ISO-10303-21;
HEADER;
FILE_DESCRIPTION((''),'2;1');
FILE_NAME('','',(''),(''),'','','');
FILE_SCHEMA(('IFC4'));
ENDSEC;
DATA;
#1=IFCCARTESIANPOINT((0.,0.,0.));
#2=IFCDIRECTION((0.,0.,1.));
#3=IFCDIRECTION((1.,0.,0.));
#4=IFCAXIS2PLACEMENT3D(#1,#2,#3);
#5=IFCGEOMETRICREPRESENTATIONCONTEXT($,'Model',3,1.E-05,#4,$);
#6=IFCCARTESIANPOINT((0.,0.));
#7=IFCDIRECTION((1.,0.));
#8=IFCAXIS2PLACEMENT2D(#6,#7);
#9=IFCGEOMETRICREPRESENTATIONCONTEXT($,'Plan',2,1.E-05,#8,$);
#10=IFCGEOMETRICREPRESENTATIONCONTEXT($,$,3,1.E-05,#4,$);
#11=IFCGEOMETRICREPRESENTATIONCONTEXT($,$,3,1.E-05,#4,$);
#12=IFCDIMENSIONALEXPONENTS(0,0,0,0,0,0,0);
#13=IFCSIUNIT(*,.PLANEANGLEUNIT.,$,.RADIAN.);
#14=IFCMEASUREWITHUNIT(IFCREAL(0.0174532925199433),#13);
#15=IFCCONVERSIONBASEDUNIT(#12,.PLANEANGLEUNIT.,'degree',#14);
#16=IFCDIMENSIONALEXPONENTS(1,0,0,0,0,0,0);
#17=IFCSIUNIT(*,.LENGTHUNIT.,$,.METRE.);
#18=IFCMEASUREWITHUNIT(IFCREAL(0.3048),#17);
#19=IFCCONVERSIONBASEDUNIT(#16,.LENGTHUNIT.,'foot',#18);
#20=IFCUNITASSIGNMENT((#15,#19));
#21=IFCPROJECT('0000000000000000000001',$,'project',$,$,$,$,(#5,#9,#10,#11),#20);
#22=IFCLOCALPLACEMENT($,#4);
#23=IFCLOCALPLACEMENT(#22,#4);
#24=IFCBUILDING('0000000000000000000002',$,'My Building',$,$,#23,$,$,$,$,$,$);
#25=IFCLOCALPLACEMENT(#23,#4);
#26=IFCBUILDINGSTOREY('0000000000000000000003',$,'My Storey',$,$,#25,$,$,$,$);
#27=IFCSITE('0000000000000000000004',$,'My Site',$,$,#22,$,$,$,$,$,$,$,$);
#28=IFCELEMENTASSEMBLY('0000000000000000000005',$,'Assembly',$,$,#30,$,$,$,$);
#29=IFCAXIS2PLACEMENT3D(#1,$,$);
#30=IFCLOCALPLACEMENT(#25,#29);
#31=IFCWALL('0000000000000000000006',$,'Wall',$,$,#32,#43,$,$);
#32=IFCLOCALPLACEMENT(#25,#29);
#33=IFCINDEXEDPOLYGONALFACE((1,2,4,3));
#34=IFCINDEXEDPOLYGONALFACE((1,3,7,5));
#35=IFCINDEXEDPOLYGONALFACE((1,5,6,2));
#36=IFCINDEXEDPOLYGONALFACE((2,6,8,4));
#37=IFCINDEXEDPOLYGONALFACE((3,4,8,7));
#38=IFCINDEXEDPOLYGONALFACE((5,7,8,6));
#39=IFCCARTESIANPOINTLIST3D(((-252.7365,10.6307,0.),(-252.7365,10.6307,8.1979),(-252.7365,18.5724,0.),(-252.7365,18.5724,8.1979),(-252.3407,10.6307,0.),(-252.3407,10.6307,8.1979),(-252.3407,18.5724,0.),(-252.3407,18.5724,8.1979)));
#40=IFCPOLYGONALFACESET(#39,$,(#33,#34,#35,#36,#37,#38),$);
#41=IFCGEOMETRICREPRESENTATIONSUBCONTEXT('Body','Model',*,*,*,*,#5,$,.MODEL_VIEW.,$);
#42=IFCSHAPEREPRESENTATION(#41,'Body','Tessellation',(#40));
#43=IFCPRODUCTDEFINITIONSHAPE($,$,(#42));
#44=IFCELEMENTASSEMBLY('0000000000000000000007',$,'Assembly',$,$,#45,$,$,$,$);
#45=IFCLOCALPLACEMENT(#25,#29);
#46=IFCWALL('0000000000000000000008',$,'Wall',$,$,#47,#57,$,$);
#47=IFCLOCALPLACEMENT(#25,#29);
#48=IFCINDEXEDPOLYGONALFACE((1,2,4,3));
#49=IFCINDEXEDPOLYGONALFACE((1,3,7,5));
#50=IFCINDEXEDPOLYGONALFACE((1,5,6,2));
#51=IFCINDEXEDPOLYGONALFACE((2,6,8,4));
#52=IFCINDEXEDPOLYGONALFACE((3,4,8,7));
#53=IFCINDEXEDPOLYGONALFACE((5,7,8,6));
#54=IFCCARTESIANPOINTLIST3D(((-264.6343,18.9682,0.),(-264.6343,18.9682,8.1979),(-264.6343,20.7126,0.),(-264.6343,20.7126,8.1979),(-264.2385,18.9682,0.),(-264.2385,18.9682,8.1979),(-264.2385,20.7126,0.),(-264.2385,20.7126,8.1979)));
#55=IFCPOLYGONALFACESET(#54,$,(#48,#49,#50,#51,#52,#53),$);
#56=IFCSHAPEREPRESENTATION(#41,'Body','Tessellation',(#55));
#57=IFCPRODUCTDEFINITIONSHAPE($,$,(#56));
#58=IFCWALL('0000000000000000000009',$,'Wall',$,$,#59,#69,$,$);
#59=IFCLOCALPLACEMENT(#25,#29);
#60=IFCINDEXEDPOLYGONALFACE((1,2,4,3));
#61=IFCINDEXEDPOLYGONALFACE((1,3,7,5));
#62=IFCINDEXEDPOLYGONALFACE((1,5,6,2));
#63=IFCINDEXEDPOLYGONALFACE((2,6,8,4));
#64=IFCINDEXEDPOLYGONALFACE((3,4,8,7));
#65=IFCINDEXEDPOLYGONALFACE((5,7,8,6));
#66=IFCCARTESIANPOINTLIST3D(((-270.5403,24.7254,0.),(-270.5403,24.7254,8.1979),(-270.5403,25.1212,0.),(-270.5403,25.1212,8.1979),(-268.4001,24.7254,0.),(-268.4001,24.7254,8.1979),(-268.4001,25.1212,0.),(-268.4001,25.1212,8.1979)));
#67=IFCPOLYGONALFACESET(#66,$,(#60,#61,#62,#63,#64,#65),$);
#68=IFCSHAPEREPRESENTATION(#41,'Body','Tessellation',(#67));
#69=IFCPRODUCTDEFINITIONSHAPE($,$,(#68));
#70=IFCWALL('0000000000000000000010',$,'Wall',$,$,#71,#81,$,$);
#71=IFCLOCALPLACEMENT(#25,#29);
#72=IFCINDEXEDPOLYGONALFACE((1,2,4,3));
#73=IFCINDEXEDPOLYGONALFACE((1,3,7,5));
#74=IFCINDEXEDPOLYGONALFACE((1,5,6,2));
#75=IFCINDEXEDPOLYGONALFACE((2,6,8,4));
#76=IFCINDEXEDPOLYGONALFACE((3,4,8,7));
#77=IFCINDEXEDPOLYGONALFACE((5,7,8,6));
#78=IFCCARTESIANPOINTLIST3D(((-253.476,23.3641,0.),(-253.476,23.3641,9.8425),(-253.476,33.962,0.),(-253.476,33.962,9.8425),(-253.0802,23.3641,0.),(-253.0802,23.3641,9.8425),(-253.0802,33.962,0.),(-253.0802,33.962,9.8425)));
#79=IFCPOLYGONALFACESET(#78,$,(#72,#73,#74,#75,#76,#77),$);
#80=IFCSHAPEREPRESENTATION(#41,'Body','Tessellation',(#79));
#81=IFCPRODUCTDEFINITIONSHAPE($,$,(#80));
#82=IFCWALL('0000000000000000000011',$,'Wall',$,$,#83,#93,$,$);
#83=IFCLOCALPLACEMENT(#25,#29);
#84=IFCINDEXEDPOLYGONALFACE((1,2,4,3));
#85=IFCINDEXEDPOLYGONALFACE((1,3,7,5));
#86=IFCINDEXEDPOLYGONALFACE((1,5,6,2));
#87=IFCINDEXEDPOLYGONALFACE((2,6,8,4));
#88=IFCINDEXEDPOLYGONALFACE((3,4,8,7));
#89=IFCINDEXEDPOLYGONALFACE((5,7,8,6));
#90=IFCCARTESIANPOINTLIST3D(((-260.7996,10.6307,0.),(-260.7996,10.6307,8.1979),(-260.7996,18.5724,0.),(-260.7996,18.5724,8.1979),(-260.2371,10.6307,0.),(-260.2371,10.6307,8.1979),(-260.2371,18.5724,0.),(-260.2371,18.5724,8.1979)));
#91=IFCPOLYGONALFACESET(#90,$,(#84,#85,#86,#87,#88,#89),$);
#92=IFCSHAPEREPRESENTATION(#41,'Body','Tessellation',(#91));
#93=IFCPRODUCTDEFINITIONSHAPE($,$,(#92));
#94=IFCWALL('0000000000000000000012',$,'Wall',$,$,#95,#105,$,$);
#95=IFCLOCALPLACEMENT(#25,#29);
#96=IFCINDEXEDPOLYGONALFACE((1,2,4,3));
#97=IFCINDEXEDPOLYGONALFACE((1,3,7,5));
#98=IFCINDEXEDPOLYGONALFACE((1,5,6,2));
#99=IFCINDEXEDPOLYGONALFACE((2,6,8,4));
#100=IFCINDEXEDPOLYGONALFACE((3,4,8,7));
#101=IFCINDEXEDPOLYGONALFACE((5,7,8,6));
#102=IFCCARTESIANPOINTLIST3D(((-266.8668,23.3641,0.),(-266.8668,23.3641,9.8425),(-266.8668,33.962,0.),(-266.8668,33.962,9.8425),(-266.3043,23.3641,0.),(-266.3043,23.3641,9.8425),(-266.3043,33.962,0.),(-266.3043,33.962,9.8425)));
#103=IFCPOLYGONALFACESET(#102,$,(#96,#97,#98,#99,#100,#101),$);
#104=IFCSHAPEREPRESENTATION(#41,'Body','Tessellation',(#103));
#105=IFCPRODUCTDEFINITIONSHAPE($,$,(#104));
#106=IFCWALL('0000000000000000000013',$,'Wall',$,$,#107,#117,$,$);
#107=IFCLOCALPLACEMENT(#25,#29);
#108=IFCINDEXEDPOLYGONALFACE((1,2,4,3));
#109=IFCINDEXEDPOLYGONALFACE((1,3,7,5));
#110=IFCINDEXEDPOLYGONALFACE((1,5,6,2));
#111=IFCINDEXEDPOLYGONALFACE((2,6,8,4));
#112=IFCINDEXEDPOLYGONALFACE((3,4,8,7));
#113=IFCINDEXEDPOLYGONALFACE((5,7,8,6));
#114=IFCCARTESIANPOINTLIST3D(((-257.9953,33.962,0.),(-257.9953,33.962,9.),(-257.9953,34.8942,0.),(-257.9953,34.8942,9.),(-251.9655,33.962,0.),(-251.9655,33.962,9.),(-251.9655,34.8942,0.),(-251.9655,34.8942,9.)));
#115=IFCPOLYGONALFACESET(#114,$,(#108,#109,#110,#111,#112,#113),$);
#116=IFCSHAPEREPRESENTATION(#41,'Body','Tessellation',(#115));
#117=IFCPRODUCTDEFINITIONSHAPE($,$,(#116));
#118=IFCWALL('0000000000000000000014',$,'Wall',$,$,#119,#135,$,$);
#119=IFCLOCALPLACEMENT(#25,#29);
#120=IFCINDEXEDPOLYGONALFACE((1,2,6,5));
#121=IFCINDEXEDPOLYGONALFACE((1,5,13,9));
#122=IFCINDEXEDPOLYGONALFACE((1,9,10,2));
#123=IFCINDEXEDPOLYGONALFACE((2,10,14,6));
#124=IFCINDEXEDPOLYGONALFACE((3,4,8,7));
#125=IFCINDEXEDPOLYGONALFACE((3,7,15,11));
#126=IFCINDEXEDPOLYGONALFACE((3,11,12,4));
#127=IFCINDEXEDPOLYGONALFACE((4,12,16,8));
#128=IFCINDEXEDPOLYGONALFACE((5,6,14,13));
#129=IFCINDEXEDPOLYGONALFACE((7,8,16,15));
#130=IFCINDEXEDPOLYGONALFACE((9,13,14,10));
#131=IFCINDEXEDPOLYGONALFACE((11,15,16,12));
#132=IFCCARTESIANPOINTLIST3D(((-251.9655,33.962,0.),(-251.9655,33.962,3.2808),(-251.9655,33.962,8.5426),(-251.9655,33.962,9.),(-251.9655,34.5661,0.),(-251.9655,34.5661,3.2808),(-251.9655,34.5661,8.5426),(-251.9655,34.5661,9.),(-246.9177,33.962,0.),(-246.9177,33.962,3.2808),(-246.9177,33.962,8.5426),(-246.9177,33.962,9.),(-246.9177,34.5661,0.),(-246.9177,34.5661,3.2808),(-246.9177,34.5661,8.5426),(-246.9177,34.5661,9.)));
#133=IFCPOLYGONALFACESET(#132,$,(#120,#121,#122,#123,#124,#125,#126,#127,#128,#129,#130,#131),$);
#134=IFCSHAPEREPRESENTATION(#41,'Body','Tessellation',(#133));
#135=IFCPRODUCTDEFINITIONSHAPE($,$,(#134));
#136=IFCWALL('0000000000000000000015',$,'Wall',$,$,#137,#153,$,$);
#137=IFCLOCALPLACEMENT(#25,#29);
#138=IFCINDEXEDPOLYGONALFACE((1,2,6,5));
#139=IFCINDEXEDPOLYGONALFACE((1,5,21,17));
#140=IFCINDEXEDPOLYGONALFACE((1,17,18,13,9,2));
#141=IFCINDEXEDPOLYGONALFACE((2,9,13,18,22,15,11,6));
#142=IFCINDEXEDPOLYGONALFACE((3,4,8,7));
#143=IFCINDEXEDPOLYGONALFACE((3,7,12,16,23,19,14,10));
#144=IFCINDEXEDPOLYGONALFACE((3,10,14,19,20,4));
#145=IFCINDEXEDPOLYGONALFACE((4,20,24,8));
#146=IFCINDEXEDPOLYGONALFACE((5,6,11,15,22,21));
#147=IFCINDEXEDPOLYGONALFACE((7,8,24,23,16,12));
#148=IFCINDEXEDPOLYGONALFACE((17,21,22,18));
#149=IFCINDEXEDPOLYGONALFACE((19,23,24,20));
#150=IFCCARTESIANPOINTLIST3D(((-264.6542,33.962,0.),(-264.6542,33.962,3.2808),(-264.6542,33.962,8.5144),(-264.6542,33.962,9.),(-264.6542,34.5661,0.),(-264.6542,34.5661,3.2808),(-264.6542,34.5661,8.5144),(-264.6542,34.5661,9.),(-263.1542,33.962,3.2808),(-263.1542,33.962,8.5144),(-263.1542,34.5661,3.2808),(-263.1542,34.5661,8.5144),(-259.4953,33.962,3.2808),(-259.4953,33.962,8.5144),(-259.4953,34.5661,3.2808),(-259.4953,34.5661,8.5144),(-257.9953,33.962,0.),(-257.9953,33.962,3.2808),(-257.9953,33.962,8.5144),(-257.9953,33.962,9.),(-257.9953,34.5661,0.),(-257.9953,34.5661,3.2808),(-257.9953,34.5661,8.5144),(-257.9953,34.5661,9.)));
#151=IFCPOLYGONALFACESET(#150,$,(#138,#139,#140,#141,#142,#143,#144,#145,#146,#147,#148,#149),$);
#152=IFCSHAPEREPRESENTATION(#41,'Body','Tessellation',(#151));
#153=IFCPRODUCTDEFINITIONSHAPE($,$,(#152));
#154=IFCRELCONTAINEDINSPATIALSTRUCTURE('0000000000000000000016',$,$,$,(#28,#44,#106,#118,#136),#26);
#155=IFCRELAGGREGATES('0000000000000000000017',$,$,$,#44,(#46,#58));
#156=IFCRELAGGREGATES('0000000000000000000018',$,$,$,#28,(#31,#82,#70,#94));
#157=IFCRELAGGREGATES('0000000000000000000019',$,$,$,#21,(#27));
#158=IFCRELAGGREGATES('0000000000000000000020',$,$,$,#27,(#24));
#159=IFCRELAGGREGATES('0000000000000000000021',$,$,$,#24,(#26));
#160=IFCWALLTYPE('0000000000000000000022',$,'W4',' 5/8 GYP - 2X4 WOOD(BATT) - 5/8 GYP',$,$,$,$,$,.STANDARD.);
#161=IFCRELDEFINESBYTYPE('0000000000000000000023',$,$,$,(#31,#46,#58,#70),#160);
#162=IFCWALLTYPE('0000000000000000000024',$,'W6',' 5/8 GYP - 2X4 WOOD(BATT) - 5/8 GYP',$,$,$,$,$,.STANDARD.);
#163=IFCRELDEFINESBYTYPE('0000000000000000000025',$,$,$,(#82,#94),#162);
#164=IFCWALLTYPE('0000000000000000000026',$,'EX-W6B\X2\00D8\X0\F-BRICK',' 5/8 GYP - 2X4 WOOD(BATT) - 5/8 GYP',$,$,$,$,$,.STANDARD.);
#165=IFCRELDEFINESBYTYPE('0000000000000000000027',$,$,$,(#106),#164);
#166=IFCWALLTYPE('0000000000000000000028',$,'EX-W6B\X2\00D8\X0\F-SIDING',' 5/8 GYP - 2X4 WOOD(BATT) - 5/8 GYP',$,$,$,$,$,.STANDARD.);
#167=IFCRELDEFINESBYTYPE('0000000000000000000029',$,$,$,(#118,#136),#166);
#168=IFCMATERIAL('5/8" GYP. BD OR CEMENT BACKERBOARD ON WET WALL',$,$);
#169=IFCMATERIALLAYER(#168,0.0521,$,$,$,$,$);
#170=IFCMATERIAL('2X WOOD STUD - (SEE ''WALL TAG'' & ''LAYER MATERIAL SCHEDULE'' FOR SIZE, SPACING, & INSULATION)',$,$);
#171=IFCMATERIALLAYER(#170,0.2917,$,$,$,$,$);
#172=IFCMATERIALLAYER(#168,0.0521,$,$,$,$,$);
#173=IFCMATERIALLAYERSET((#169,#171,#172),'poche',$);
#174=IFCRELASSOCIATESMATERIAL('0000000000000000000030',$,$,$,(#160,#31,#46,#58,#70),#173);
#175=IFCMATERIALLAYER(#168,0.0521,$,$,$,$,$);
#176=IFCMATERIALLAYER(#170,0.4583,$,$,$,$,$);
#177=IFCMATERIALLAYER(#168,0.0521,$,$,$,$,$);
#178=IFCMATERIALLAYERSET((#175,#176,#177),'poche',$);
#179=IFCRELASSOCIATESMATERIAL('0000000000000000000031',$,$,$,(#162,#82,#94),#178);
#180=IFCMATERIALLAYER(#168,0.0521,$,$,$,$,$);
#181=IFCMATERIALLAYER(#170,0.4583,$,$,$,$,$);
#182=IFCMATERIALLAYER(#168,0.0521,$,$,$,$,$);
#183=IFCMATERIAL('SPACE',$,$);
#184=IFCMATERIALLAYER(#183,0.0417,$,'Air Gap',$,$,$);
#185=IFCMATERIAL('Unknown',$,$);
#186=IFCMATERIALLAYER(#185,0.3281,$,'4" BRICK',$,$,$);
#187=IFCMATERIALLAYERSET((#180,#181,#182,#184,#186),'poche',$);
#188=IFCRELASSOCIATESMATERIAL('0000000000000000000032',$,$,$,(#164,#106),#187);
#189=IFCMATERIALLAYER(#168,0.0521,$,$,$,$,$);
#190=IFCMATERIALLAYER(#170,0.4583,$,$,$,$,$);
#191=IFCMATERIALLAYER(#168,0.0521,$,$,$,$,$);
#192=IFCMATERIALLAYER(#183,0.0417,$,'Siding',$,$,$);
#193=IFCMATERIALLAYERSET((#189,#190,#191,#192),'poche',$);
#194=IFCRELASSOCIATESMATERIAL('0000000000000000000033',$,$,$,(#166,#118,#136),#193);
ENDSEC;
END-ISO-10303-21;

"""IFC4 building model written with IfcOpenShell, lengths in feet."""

from ifc_helpers import new_model, entity, si_unit, converted_unit, frame, origin_with_axes, origin_2d_with_axis, place, context, subcontext, project, spatial, line, indexed_curve, outline, extrude, source, transform, mapped, material, layer, layer_set, layer_usage, type_object, element, aggregate, save


model = new_model("IFC4")

# Units and contexts
model_context = context("Model", 3, precision=1e-05, world=origin_with_axes())
plan_context = context("Plan", 2, precision=1e-05, world=origin_2d_with_axis())
context_of_model_1 = context(None, 3, precision=1e-05, world=origin_with_axes())
context_of_model_2 = context(None, 3, precision=1e-05, world=origin_with_axes())
body_context_1 = subcontext(model_context, "Body", "Model", "MODEL_VIEW")
ifc_project = project(units=[converted_unit("PLANEANGLEUNIT", "degree", entity("IfcReal", 0.0174532925199433), si_unit("PLANEANGLEUNIT", "RADIAN"), dimensions=[0, 0, 0, 0, 0, 0, 0]), converted_unit("LENGTHUNIT", "foot", entity("IfcReal", 0.3048), si_unit("LENGTHUNIT", "METRE"), dimensions=[1, 0, 0, 0, 0, 0, 0])], contexts=[model_context, plan_context, context_of_model_1, context_of_model_2])

# Site, building, storey
site_placement = place(None, origin_with_axes())
site = spatial("IfcSite", under=ifc_project, at=site_placement, Name="My Site")
building_placement = place(site_placement, origin_with_axes())
building = spatial("IfcBuilding", under=site, at=building_placement, Name="My Building")
storey_placement = place(building_placement, origin_with_axes())
storey = spatial("IfcBuildingStorey", under=building, at=storey_placement, Name="My Storey")

# Element assembly, wall
assembly_1_placement = place(storey_placement, origin_with_axes())
assembly_1 = element("IfcElementAssembly", 1, at=assembly_1_placement, inside=storey, Name="Assembly")
ifc_material_1 = material(Name="5/8\" GYP. BD OR CEMENT BACKERBOARD ON WET WALL")
ifc_layer_1 = layer(ifc_material_1, 0.0521)
ifc_material_2 = material(Name="2X WOOD STUD - (SEE 'WALL TAG' & 'LAYER MATERIAL SCHEDULE' FOR SIZE, SPACING, & INSULATION)")
ifc_layer_2 = layer(ifc_material_2, 0.2917)
ifc_layer_3 = layer(ifc_material_1, 0.0521)
ifc_layer_set_1 = layer_set([ifc_layer_1, ifc_layer_2, ifc_layer_3], Name="poche")
ifc_layer_usage_1 = layer_usage(ifc_layer_set_1, "AXIS2", "POSITIVE", 0.0)
wall_type_1 = type_object("IfcWallType", Name="W4", Description=" 5/8 GYP - 2X4 WOOD(BATT) - 5/8 GYP", PredefinedType="STANDARD", material=ifc_layer_set_1)
wall_1_placement = place(assembly_1_placement, frame((-252.7365, 18.5724, 0.0), z_axis=(0.0, 0.0, 1.0), x_axis=(0.0, -1.0, 0.0)))
wall_1 = element("IfcWall", 2, at=wall_1_placement, type_object=wall_type_1, material=ifc_layer_usage_1, Name="Wall", context=body_context_1, shape_type="SweptSolid", body=[
    extrude(outline(indexed_curve([(0.0, 0.0), (0.0, 0.3958), (7.9417, 0.3958), (7.9417, 0.0), (0.0, 0.0)], self_intersect=False)), origin_with_axes(), (0.0, 0.0, 1.0), 8.1979),
])

# Element assembly, walls
assembly_2_placement = place(storey_placement, origin_with_axes())
assembly_2 = element("IfcElementAssembly", 3, at=assembly_2_placement, inside=storey, Name="Assembly")
ifc_layer_usage_2 = layer_usage(ifc_layer_set_1, "AXIS2", "POSITIVE", 0.0)
wall_2_placement = place(assembly_2_placement, frame((-264.6343, 20.7126, 0.0), z_axis=(0.0, 0.0, 1.0), x_axis=(0.0, -1.0, 0.0)))
wall_2 = element("IfcWall", 4, at=wall_2_placement, type_object=wall_type_1, material=ifc_layer_usage_2, Name="Wall", context=body_context_1, shape_type="SweptSolid", body=[
    extrude(outline(indexed_curve([(0.0, 0.0), (0.0, 0.3958), (1.7443, 0.3958), (1.7443, 0.0), (0.0, 0.0)], self_intersect=False)), origin_with_axes(), (0.0, 0.0, 1.0), 8.1979),
])
ifc_layer_usage_3 = layer_usage(ifc_layer_set_1, "AXIS2", "POSITIVE", 0.0)
wall_3_placement = place(assembly_2_placement, frame((-268.4001, 25.1212, 0.0), z_axis=(0.0, 0.0, 1.0), x_axis=(-1.0, 0.0, 0.0)))
wall_3 = element("IfcWall", 5, at=wall_3_placement, type_object=wall_type_1, material=ifc_layer_usage_3, Name="Wall", context=body_context_1, shape_type="SweptSolid", body=[
    extrude(outline(indexed_curve([(0.0, 0.0), (0.0, 0.3958), (2.1402, 0.3958), (2.1402, 0.0), (0.0, 0.0)], self_intersect=False)), origin_with_axes(), (0.0, 0.0, 1.0), 8.1979),
])
aggregate(assembly_2, [wall_2, wall_3])

# Wall
ifc_layer_usage_4 = layer_usage(ifc_layer_set_1, "AXIS2", "POSITIVE", 0.0)
wall_4_placement = place(assembly_1_placement, frame((-253.0802, 23.3641, 0.0), z_axis=(0.0, 0.0, 1.0), x_axis=(0.0, 1.0, 0.0)))
wall_4 = element("IfcWall", 6, at=wall_4_placement, type_object=wall_type_1, material=ifc_layer_usage_4, Name="Wall", context=body_context_1, shape_type="SweptSolid", body=[
    extrude(outline(indexed_curve([(0.0, 0.0), (0.0, 0.3958), (10.5979, 0.3958), (10.5979, 0.0), (0.0, 0.0)], self_intersect=False)), origin_with_axes(), (0.0, 0.0, 1.0), 9.8425),
])

# Walls
ifc_layer_4 = layer(ifc_material_1, 0.0521)
ifc_layer_5 = layer(ifc_material_2, 0.4583)
ifc_layer_6 = layer(ifc_material_1, 0.0521)
ifc_layer_set_2 = layer_set([ifc_layer_4, ifc_layer_5, ifc_layer_6], Name="poche")
ifc_layer_usage_5 = layer_usage(ifc_layer_set_2, "AXIS2", "POSITIVE", 0.0)
wall_type_2 = type_object("IfcWallType", Name="W6", Description=" 5/8 GYP - 2X4 WOOD(BATT) - 5/8 GYP", PredefinedType="STANDARD", material=ifc_layer_set_2)
wall_5_placement = place(assembly_1_placement, frame((-260.7996, 18.5724, 0.0), z_axis=(0.0, 0.0, 1.0), x_axis=(0.0, -1.0, 0.0)))
wall_5 = element("IfcWall", 7, at=wall_5_placement, type_object=wall_type_2, material=ifc_layer_usage_5, Name="Wall", context=body_context_1, shape_type="SweptSolid", body=[
    extrude(outline(indexed_curve([(0.0, 0.0), (0.0, 0.5625), (7.9417, 0.5625), (7.9417, 0.0), (0.0, 0.0)], self_intersect=False)), origin_with_axes(), (0.0, 0.0, 1.0), 8.1979),
])
ifc_layer_usage_6 = layer_usage(ifc_layer_set_2, "AXIS2", "POSITIVE", 0.0)
wall_6_placement = place(assembly_1_placement, frame((-266.3043, 23.3641, 0.0), z_axis=(0.0, 0.0, 1.0), x_axis=(0.0, 1.0, 0.0)))
wall_6 = element("IfcWall", 8, at=wall_6_placement, type_object=wall_type_2, material=ifc_layer_usage_6, Name="Wall", context=body_context_1, shape_type="SweptSolid", body=[
    extrude(outline(indexed_curve([(0.0, 0.0), (0.0, 0.5625), (10.5979, 0.5625), (10.5979, 0.0), (0.0, 0.0)], self_intersect=False)), origin_with_axes(), (0.0, 0.0, 1.0), 9.8425),
])
ifc_layer_7 = layer(ifc_material_1, 0.0521)
ifc_layer_8 = layer(ifc_material_2, 0.4583)
ifc_layer_9 = layer(ifc_material_1, 0.0521)
ifc_material_3 = material(Name="SPACE")
ifc_layer_10 = layer(ifc_material_3, 0.0417, Name="Air Gap")
ifc_material_4 = material(Name="Unknown")
ifc_layer_11 = layer(ifc_material_4, 0.3281, Name="4\" BRICK")
ifc_layer_set_3 = layer_set([ifc_layer_7, ifc_layer_8, ifc_layer_9, ifc_layer_10, ifc_layer_11], Name="poche")
ifc_layer_usage_7 = layer_usage(ifc_layer_set_3, "AXIS2", "POSITIVE", 0.0)
wall_type_3 = type_object("IfcWallType", Name="EX-W6BØF-BRICK", Description=" 5/8 GYP - 2X4 WOOD(BATT) - 5/8 GYP", PredefinedType="STANDARD", material=ifc_layer_set_3)
wall_7_placement = place(storey_placement, frame((-257.9953, 33.962, 0.0), z_axis=(0.0, 0.0, 1.0), x_axis=(1.0, 0.0, 0.0)))
element("IfcWall", 9, at=wall_7_placement, inside=storey, type_object=wall_type_3, material=ifc_layer_usage_7, Name="Wall", context=body_context_1, shape_type="SweptSolid", body=[
    extrude(outline(indexed_curve([(0.0, 0.0), (0.0, 0.9323), (6.0297, 0.9323), (6.0297, 0.0), (0.0, 0.0)], self_intersect=False)), origin_with_axes(), (0.0, 0.0, 1.0), 9.0),
])

# Wall, opening
ifc_layer_12 = layer(ifc_material_1, 0.0521)
ifc_layer_13 = layer(ifc_material_2, 0.4583)
ifc_layer_14 = layer(ifc_material_1, 0.0521)
ifc_layer_15 = layer(ifc_material_3, 0.0417, Name="Siding")
ifc_layer_set_4 = layer_set([ifc_layer_12, ifc_layer_13, ifc_layer_14, ifc_layer_15], Name="poche")
ifc_layer_usage_8 = layer_usage(ifc_layer_set_4, "AXIS2", "POSITIVE", 0.0)
wall_type_4 = type_object("IfcWallType", Name="EX-W6BØF-SIDING", Description=" 5/8 GYP - 2X4 WOOD(BATT) - 5/8 GYP", PredefinedType="STANDARD", material=ifc_layer_set_4)
wall_8_placement = place(storey_placement, frame((-251.9655, 33.962, 0.0), z_axis=(0.0, 0.0, 1.0), x_axis=(1.0, 0.0, 0.0)))
wall_8 = element("IfcWall", 10, at=wall_8_placement, inside=storey, type_object=wall_type_4, material=ifc_layer_usage_8, Name="Wall", context=body_context_1, shape_type="SweptSolid", body=[
    extrude(outline(indexed_curve([(0.0, 0.0), (0.0, 0.6042), (5.0478, 0.6042), (5.0478, 0.0), (0.0, 0.0)], self_intersect=False)), origin_with_axes(), (0.0, 0.0, 1.0), 9.0),
])
shared_shape_1 = source(origin_with_axes(), body_context_1, "Body", "SweptSolid", [
    extrude(outline(indexed_curve([(0.0, 0.0), (5.0478, 0.0), (5.0478, 5.2618), (0.0, 5.2618)], segments=[line(1, 2, 3, 4, 1)])), frame((0.0, -0.3281, 0.0), z_axis=(0.0, -1.0, 0.0), x_axis=(1.0, 0.0, 0.0)), (0.0, 0.0, -1.0), 1.2603),
])
opening_1_placement = place(wall_8_placement, frame((0.0, 0.0, 3.2808), z_axis=(0.0, 0.0, 1.0), x_axis=(1.0, 0.0, 0.0)))
element("IfcOpeningElement", 11, at=opening_1_placement, cuts=wall_8, PredefinedType="OPENING", context=body_context_1, shape_type="MappedRepresentation", body=[
    mapped(shared_shape_1, transform((0.0, 0.0, 0.0), x_axis=(1.0, 0.0, 0.0), y_axis=(0.0, 1.0, 0.0), z_axis=(0.0, 0.0, 1.0), scale=1.0)),
])

# Wall, openings
ifc_layer_usage_9 = layer_usage(ifc_layer_set_4, "AXIS2", "POSITIVE", 0.0)
wall_9_placement = place(storey_placement, frame((-264.6542, 33.962, 0.0), z_axis=(0.0, 0.0, 1.0), x_axis=(1.0, 0.0, 0.0)))
wall_9 = element("IfcWall", 12, at=wall_9_placement, inside=storey, type_object=wall_type_4, material=ifc_layer_usage_9, Name="Wall", context=body_context_1, shape_type="SweptSolid", body=[
    extrude(outline(indexed_curve([(0.0, 0.0), (0.0, 0.6042), (6.6589, 0.6042), (6.6589, 0.0), (0.0, 0.0)], self_intersect=False)), origin_with_axes(), (0.0, 0.0, 1.0), 9.0),
])
shared_shape_2 = source(origin_with_axes(), body_context_1, "Body", "SweptSolid", [
    extrude(outline(indexed_curve([(0.0, 0.0), (1.5, 0.0), (1.5, 5.2335), (0.0, 5.2335)], segments=[line(1, 2, 3, 4, 1)])), frame((0.0, -0.3281, 0.0), z_axis=(0.0, -1.0, 0.0), x_axis=(1.0, 0.0, 0.0)), (0.0, 0.0, -1.0), 1.2603),
])
opening_2_placement = place(wall_9_placement, frame((0.0, 0.0, 3.2808), z_axis=(0.0, 0.0, 1.0), x_axis=(1.0, 0.0, 0.0)))
element("IfcOpeningElement", 13, at=opening_2_placement, cuts=wall_9, PredefinedType="OPENING", context=body_context_1, shape_type="MappedRepresentation", body=[
    mapped(shared_shape_2, transform((0.0, 0.0, 0.0), x_axis=(1.0, 0.0, 0.0), y_axis=(0.0, 1.0, 0.0), z_axis=(0.0, 0.0, 1.0), scale=1.0)),
])
opening_3_placement = place(wall_9_placement, frame((5.1589, 0.0, 3.2808), z_axis=(0.0, 0.0, 1.0), x_axis=(1.0, 0.0, 0.0)))
element("IfcOpeningElement", 14, at=opening_3_placement, cuts=wall_9, PredefinedType="OPENING", context=body_context_1, shape_type="MappedRepresentation", body=[
    mapped(shared_shape_2, transform((0.0, 0.0, 0.0), x_axis=(1.0, 0.0, 0.0), y_axis=(0.0, 1.0, 0.0), z_axis=(0.0, 0.0, 1.0), scale=1.0)),
])
shared_shape_3 = source(origin_with_axes(), body_context_1, "Body", "SweptSolid", [
    extrude(outline(indexed_curve([(0.0, 0.0), (3.6589, 0.0), (3.6589, 5.2335), (0.0, 5.2335)], segments=[line(1, 2, 3, 4, 1)])), frame((0.0, -0.3281, 0.0), z_axis=(0.0, -1.0, 0.0), x_axis=(1.0, 0.0, 0.0)), (0.0, 0.0, -1.0), 1.2603),
])
opening_4_placement = place(wall_9_placement, frame((1.5, 0.0, 3.2808), z_axis=(0.0, 0.0, 1.0), x_axis=(1.0, 0.0, 0.0)))
element("IfcOpeningElement", 15, at=opening_4_placement, cuts=wall_9, PredefinedType="OPENING", context=body_context_1, shape_type="MappedRepresentation", body=[
    mapped(shared_shape_3, transform((0.0, 0.0, 0.0), x_axis=(1.0, 0.0, 0.0), y_axis=(0.0, 1.0, 0.0), z_axis=(0.0, 0.0, 1.0), scale=1.0)),
])

aggregate(assembly_1, [wall_1, wall_5, wall_4, wall_6])

save(model, "model.ifc")
